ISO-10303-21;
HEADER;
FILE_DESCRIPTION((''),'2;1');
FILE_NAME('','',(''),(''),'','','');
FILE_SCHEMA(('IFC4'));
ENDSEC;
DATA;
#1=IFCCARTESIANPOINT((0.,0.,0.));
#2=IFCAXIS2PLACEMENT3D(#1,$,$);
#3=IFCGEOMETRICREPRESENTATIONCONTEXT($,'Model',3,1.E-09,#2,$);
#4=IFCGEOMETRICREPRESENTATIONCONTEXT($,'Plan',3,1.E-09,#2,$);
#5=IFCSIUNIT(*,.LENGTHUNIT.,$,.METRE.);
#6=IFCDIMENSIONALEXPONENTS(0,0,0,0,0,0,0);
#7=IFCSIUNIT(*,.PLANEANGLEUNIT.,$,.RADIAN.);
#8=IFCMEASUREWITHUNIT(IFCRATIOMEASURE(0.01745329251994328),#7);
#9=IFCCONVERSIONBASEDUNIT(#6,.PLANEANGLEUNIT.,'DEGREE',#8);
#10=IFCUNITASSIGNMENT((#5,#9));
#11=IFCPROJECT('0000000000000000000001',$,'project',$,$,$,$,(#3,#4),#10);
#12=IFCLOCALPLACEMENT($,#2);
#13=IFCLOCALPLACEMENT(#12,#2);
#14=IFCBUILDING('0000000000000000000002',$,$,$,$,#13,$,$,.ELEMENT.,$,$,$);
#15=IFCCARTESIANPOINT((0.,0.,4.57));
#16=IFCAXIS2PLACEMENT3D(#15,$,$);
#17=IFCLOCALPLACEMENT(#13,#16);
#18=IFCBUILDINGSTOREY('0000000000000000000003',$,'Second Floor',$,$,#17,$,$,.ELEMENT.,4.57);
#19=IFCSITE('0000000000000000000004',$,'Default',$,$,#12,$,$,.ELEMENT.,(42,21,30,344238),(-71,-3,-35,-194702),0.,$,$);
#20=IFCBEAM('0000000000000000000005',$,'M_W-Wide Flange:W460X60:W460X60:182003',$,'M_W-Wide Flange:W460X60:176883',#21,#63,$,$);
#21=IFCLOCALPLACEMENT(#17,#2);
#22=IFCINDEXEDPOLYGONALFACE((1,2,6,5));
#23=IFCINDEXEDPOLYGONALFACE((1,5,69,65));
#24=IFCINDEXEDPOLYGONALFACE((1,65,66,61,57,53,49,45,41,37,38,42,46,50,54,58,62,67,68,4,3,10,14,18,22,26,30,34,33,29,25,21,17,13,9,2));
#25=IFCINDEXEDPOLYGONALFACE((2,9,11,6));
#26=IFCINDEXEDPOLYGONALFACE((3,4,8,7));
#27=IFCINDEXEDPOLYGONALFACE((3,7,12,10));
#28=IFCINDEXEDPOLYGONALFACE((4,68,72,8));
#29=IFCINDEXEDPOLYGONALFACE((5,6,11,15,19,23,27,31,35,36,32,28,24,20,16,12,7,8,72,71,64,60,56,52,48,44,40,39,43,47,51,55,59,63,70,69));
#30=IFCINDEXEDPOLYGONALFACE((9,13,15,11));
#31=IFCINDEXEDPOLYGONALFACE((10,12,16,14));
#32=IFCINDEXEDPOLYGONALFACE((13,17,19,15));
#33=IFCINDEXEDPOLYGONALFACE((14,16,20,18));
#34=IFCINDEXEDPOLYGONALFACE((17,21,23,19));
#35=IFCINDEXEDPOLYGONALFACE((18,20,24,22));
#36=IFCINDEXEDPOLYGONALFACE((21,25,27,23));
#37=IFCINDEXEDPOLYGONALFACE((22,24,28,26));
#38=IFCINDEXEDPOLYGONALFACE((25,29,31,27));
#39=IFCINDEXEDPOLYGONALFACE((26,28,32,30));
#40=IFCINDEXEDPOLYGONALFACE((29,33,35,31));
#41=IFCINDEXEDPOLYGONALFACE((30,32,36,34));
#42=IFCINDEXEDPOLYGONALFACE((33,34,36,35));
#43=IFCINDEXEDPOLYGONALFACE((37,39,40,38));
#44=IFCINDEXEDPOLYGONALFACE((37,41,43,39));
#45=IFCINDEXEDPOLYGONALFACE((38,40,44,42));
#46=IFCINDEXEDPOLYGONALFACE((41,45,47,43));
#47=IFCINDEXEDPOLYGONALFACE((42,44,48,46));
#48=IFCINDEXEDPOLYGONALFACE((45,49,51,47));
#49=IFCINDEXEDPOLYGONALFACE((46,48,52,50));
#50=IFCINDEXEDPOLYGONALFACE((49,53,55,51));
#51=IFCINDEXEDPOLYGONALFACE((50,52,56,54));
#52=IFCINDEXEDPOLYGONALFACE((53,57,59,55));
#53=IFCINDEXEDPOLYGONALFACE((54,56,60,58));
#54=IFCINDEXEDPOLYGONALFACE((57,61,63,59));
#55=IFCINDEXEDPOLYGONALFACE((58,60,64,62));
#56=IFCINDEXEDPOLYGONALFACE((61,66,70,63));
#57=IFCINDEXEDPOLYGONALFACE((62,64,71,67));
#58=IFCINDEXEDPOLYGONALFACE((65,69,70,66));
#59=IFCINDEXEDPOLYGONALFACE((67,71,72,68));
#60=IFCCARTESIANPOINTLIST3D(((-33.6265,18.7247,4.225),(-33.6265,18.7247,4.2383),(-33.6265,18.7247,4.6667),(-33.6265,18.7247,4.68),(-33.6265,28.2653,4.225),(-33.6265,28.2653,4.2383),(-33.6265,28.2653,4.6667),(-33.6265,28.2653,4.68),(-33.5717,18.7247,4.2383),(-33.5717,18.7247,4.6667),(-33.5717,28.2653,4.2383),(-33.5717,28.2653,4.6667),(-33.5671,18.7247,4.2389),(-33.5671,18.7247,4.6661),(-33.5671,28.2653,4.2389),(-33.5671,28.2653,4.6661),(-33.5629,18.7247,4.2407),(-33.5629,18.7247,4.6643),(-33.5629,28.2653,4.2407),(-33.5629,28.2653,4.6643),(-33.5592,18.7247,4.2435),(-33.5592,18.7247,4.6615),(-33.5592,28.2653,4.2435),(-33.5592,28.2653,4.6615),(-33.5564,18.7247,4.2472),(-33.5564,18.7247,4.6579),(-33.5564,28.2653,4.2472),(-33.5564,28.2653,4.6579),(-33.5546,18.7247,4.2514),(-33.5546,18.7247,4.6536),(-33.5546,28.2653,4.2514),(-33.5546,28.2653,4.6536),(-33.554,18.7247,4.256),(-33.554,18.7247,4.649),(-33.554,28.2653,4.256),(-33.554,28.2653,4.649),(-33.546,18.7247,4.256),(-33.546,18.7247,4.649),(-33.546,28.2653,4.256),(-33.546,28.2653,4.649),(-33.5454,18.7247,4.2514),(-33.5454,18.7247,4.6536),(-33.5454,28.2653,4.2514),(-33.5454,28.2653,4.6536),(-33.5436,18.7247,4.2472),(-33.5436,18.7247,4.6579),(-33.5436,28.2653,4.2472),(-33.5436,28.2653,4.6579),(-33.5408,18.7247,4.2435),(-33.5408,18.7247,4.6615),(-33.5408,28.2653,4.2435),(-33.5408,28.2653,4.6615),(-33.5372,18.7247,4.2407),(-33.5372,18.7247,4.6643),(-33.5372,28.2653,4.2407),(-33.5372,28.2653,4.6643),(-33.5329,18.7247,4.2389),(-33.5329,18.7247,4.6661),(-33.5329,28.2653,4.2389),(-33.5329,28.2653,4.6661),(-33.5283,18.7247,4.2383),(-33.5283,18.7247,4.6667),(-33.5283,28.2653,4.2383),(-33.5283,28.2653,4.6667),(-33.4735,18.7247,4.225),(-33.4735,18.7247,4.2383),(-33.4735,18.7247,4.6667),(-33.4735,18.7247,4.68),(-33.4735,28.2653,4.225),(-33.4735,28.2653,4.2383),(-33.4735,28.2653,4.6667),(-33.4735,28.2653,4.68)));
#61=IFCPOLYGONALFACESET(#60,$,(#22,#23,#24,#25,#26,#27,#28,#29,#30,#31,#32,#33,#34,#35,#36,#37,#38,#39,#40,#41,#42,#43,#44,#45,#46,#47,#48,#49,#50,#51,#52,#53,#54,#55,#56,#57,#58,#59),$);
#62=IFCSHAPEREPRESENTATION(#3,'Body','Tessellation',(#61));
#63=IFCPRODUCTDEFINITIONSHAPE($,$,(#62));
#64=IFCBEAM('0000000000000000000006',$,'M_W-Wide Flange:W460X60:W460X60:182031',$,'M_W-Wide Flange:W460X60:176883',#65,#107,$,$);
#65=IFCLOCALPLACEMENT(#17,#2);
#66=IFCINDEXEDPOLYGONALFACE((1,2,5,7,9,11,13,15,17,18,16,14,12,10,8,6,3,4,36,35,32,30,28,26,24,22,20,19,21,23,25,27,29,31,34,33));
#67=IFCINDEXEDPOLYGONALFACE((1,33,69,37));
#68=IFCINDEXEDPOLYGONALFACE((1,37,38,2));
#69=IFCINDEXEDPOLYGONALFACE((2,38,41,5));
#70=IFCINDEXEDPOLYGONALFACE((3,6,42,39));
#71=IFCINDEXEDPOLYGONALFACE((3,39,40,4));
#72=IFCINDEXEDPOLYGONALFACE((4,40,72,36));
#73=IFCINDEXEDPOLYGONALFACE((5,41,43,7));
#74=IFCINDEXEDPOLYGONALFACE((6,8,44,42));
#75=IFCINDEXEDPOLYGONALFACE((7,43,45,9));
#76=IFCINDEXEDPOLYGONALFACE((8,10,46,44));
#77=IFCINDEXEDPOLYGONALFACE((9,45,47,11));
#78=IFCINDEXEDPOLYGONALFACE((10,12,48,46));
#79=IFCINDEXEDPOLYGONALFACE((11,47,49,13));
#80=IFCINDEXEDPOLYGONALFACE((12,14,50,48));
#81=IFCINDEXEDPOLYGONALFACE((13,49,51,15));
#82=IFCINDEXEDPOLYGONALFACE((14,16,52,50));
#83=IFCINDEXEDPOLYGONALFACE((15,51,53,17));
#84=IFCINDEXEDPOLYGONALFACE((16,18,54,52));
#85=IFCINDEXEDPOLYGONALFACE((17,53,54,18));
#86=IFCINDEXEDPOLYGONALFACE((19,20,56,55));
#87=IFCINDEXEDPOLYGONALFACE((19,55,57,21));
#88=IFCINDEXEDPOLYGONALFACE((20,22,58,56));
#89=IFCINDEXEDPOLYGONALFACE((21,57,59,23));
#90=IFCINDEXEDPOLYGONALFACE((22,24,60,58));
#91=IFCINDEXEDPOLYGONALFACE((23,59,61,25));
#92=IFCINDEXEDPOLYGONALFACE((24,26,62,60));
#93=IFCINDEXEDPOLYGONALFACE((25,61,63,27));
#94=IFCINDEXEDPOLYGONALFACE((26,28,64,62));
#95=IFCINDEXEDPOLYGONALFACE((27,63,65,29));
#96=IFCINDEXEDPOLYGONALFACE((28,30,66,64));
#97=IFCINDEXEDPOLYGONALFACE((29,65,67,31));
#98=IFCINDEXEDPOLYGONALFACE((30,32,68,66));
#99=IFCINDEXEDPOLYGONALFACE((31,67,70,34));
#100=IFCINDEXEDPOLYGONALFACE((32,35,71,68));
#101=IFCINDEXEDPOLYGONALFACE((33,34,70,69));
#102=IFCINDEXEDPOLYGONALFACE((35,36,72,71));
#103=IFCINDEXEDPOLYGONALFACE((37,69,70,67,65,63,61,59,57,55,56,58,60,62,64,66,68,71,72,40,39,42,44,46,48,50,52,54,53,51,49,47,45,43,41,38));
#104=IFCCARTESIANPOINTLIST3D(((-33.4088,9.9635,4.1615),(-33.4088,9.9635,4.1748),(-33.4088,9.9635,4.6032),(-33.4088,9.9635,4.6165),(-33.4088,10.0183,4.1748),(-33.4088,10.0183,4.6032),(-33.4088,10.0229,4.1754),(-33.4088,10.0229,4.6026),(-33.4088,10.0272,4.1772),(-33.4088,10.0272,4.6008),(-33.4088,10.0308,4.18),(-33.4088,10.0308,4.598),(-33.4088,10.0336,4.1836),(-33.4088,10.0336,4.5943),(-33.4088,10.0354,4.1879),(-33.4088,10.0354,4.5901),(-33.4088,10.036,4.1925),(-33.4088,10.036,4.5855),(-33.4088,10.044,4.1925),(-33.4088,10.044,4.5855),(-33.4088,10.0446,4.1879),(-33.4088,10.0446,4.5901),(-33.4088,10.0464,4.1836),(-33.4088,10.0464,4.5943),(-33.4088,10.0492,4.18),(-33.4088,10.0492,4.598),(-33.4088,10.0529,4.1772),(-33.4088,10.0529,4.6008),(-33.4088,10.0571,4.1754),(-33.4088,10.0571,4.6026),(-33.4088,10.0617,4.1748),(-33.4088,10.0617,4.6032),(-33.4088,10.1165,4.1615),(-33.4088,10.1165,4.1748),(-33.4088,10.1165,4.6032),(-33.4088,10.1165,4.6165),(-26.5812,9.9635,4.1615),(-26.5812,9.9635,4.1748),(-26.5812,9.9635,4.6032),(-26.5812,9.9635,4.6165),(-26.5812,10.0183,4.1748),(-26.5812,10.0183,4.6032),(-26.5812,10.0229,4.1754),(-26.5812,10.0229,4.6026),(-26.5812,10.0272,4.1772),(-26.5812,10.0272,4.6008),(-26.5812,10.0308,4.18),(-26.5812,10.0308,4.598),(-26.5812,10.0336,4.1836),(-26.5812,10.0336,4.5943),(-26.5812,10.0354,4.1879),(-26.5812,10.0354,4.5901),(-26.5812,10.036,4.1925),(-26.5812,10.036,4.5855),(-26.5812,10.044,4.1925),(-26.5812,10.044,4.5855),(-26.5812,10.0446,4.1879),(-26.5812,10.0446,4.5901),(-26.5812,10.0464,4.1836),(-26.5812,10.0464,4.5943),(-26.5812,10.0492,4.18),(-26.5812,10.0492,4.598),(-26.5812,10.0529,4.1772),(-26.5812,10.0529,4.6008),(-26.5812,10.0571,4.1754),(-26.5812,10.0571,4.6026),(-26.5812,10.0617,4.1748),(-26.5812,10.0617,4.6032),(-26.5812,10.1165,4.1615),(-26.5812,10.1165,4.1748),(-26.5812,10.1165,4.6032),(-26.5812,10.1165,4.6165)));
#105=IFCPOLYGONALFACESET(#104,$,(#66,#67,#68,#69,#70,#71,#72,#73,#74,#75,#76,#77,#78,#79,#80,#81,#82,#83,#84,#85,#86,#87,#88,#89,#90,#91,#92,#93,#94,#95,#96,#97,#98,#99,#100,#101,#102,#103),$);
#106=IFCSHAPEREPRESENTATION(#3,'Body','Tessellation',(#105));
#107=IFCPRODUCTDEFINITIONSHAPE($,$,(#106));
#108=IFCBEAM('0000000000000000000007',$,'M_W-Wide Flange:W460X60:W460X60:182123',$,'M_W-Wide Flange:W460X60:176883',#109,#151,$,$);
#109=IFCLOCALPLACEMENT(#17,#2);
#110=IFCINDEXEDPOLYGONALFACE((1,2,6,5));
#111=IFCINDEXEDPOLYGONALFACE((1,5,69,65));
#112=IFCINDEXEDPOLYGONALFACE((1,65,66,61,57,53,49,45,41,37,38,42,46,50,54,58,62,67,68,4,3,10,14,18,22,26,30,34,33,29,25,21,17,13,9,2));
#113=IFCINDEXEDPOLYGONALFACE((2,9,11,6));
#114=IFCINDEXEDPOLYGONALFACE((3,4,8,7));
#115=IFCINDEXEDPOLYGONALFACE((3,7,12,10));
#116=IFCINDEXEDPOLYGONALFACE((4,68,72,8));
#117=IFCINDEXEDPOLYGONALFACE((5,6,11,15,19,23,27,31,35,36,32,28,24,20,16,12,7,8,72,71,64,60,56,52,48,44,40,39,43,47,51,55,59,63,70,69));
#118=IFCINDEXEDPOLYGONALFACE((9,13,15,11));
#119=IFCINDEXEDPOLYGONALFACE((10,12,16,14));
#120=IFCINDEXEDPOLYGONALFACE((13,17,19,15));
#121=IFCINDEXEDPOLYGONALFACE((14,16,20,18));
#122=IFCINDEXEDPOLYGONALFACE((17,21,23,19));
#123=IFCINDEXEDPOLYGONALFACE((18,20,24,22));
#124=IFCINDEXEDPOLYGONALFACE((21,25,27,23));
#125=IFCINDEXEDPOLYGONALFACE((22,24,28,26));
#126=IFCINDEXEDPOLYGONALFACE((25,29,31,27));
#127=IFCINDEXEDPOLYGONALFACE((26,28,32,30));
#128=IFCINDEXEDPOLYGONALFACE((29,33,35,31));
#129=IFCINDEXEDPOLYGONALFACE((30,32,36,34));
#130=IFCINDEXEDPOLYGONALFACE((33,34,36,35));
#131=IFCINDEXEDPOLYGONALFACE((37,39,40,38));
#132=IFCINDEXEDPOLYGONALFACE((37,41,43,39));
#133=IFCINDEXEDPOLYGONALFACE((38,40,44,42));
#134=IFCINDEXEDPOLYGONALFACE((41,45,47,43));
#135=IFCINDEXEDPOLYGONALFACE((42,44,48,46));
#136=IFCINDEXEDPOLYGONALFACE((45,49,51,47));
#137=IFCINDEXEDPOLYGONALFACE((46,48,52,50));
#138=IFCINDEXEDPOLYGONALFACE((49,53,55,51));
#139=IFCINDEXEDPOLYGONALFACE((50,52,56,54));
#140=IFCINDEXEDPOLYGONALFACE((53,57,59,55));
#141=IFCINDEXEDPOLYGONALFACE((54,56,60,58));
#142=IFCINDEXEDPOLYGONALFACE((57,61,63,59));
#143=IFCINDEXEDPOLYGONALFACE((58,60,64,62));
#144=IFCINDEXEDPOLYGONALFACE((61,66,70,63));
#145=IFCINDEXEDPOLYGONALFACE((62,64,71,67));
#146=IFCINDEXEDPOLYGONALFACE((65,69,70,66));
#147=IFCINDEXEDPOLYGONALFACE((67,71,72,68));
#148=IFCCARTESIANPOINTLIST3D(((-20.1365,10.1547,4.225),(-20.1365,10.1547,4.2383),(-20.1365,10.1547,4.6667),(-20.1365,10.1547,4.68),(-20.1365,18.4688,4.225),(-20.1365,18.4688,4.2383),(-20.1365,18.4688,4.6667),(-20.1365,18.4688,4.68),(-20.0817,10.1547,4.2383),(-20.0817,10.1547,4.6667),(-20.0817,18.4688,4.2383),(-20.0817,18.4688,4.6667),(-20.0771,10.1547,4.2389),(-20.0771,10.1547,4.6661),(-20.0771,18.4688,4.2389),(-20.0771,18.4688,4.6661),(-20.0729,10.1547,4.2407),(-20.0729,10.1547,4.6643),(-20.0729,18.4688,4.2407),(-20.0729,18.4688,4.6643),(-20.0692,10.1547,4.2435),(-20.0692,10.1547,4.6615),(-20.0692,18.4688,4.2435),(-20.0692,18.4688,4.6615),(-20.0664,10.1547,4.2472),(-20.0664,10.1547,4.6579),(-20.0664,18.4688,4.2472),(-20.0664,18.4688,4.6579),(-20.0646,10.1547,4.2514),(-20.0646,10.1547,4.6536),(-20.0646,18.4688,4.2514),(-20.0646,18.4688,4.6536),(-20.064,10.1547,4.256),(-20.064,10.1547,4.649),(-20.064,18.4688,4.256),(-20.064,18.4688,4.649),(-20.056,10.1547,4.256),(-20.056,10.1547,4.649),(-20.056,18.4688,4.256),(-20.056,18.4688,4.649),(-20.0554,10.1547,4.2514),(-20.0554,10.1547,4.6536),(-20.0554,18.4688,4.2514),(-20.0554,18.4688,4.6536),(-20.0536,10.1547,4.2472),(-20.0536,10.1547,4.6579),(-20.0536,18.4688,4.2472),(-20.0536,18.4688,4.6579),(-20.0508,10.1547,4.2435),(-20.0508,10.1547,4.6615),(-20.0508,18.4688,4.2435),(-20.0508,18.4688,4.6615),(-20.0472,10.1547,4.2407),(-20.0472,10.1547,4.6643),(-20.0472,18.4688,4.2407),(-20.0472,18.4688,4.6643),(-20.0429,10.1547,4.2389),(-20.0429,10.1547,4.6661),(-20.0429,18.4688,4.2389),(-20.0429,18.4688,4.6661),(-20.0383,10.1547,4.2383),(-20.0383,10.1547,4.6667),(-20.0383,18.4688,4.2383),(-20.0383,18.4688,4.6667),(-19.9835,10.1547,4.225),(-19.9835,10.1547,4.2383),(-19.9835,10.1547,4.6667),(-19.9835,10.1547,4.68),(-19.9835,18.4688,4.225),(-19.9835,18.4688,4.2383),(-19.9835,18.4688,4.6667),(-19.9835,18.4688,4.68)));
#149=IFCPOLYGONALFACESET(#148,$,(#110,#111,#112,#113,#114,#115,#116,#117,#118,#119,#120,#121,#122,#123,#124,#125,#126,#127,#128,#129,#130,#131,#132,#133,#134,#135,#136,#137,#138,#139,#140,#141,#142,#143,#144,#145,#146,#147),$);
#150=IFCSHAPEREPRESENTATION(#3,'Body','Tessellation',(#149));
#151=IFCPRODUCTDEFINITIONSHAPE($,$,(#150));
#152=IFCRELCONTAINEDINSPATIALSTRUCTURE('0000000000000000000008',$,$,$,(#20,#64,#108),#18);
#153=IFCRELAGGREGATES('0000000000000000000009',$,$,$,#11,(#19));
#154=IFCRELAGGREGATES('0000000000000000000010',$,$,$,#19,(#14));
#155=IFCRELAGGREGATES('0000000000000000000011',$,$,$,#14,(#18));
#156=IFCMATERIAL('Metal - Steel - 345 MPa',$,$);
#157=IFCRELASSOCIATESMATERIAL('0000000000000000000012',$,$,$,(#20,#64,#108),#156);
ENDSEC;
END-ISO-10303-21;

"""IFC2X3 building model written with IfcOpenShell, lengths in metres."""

from ifc_helpers import new_model, entity, si_unit, converted_unit, frame, frame_2d, origin, place, context, project, spatial, polyline, circle_curve, parameter, trimmed, segment, composite_curve, outline, extrude, material, element, save


model = new_model("IFC2X3")

# Units and contexts
model_context = context("Model", 3, precision=1e-09, world=origin())
plan_context = context("Plan", 3, precision=1e-09, world=origin())
ifc_project = project(units=[si_unit("LENGTHUNIT", "METRE"), converted_unit("PLANEANGLEUNIT", "DEGREE", entity("IfcRatioMeasure", 0.01745329251994328), si_unit("PLANEANGLEUNIT", "RADIAN"), dimensions=[0, 0, 0, 0, 0, 0, 0])], contexts=[model_context, plan_context])

# Site, building, storey
site_placement = place(None, origin())
site = spatial("IfcSite", under=ifc_project, at=site_placement, Name="Default", CompositionType="ELEMENT", RefLatitude=(42, 21, 30, 344238), RefLongitude=(-71, -3, -35, -194702), RefElevation=0.0)
building_placement = place(site_placement, origin())
building = spatial("IfcBuilding", under=site, at=building_placement, CompositionType="ELEMENT")
storey_placement = place(building_placement, frame((0.0, 0.0, 4.57)))
storey = spatial("IfcBuildingStorey", under=building, at=storey_placement, Name="Second Floor", CompositionType="ELEMENT", Elevation=4.57)

# Shared definitions
ifc_material = material(Name="Metal - Steel - 345 MPa")

# Beams
beam_1_placement = place(storey_placement, frame((-33.55, 28.3781, 4.68), z_axis=(0.0, 0.0, 1.0), x_axis=(-1.0, 0.0, 0.0)))
element("IfcBeam", 1, at=beam_1_placement, inside=storey, material=ifc_material, Name="M_W-Wide Flange:W460X60:W460X60:182003", ObjectType="M_W-Wide Flange:W460X60:176883", context=model_context, shape_type="SweptSolid", body=[
    extrude(outline(composite_curve([segment(polyline([(0.2142, -0.0765), (0.2275, -0.0765)]), True, "CONTINUOUS"), segment(polyline([(0.2275, -0.0765), (0.2275, 0.0765)]), True, "CONTINUOUS"), segment(polyline([(0.2275, 0.0765), (0.2142, 0.0765)]), True, "CONTINUOUS"), segment(polyline([(0.2142, 0.0765), (0.2142, 0.0217)]), True, "CONTINUOUS"), segment(trimmed(circle_curve(frame_2d((0.1965, 0.0217), x_axis=(1.0, 0.0)), 0.0177), [parameter(270.0)], [parameter(360.0)], True, "PARAMETER"), False, "CONTINUOUS"), segment(polyline([(0.1965, 0.004), (-0.1965, 0.004)]), True, "CONTINUOUS"), segment(trimmed(circle_curve(frame_2d((-0.1965, 0.0217), x_axis=(0.0, -1.0)), 0.0177), [parameter(270.0)], [parameter(360.0)], True, "PARAMETER"), False, "CONTINUOUS"), segment(polyline([(-0.2142, 0.0217), (-0.2142, 0.0765)]), True, "CONTINUOUS"), segment(polyline([(-0.2142, 0.0765), (-0.2275, 0.0765)]), True, "CONTINUOUS"), segment(polyline([(-0.2275, 0.0765), (-0.2275, -0.0765)]), True, "CONTINUOUS"), segment(polyline([(-0.2275, -0.0765), (-0.2142, -0.0765)]), True, "CONTINUOUS"), segment(polyline([(-0.2142, -0.0765), (-0.2142, -0.0217)]), True, "CONTINUOUS"), segment(trimmed(circle_curve(frame_2d((-0.1965, -0.0217), x_axis=(-1.0, 0.0)), 0.0177), [parameter(270.0)], [parameter(360.0)], True, "PARAMETER"), False, "CONTINUOUS"), segment(polyline([(-0.1965, -0.004), (0.1965, -0.004)]), True, "CONTINUOUS"), segment(trimmed(circle_curve(frame_2d((0.1965, -0.0217), x_axis=(0.0, 1.0)), 0.0177), [parameter(270.0)], [parameter(0.0)], True, "PARAMETER"), False, "CONTINUOUS"), segment(polyline([(0.2142, -0.0217), (0.2142, -0.0765)]), True, "CONTINUOUS")], self_intersect=False)), frame((0.0, 9.6534, -0.2275), z_axis=(0.0, -1.0, 0.0), x_axis=(0.0, 0.0, -1.0)), (0.0, 0.0, 1.0), 9.5406),
])
beam_2_placement = place(storey_placement, frame((-33.5473, 10.04, 4.6165), z_axis=(0.0, 0.0, 1.0), x_axis=(0.0, -1.0, 0.0)))
element("IfcBeam", 2, at=beam_2_placement, inside=storey, material=ifc_material, Name="M_W-Wide Flange:W460X60:W460X60:182031", ObjectType="M_W-Wide Flange:W460X60:176883", context=model_context, shape_type="SweptSolid", body=[
    extrude(outline(composite_curve([segment(polyline([(-0.0765, -0.2142), (-0.0765, -0.2275)]), True, "CONTINUOUS"), segment(polyline([(-0.0765, -0.2275), (0.0765, -0.2275)]), True, "CONTINUOUS"), segment(polyline([(0.0765, -0.2275), (0.0765, -0.2142)]), True, "CONTINUOUS"), segment(polyline([(0.0765, -0.2142), (0.0217, -0.2142)]), True, "CONTINUOUS"), segment(trimmed(circle_curve(frame_2d((0.0217, -0.1965), x_axis=(0.0, -1.0)), 0.0177), [parameter(270.0)], [parameter(360.0)], True, "PARAMETER"), False, "CONTINUOUS"), segment(polyline([(0.004, -0.1965), (0.004, 0.1965)]), True, "CONTINUOUS"), segment(trimmed(circle_curve(frame_2d((0.0217, 0.1965), x_axis=(-1.0, 0.0)), 0.0177), [parameter(270.0)], [parameter(360.0)], True, "PARAMETER"), False, "CONTINUOUS"), segment(polyline([(0.0217, 0.2142), (0.0765, 0.2142)]), True, "CONTINUOUS"), segment(polyline([(0.0765, 0.2142), (0.0765, 0.2275)]), True, "CONTINUOUS"), segment(polyline([(0.0765, 0.2275), (-0.0765, 0.2275)]), True, "CONTINUOUS"), segment(polyline([(-0.0765, 0.2275), (-0.0765, 0.2142)]), True, "CONTINUOUS"), segment(polyline([(-0.0765, 0.2142), (-0.0217, 0.2142)]), True, "CONTINUOUS"), segment(trimmed(circle_curve(frame_2d((-0.0217, 0.1965), x_axis=(0.0, 1.0)), 0.0177), [parameter(270.0)], [parameter(360.0)], True, "PARAMETER"), False, "CONTINUOUS"), segment(polyline([(-0.004, 0.1965), (-0.004, -0.1965)]), True, "CONTINUOUS"), segment(trimmed(circle_curve(frame_2d((-0.0217, -0.1965), x_axis=(1.0, 0.0)), 0.0177), [parameter(270.0)], [parameter(0.0)], True, "PARAMETER"), False, "CONTINUOUS"), segment(polyline([(-0.0217, -0.2142), (-0.0765, -0.2142)]), True, "CONTINUOUS")], self_intersect=False)), frame((0.0, 0.1385, -0.2275), z_axis=(0.0, -1.0, 0.0), x_axis=(1.0, 0.0, 0.0)), (0.0, 0.0, -1.0), 6.8276),
])
beam_3_placement = place(storey_placement, frame((-20.06, 10.0422, 4.68)))
element("IfcBeam", 3, at=beam_3_placement, inside=storey, material=ifc_material, Name="M_W-Wide Flange:W460X60:W460X60:182123", ObjectType="M_W-Wide Flange:W460X60:176883", context=model_context, shape_type="SweptSolid", body=[
    extrude(outline(composite_curve([segment(polyline([(-0.0765, -0.2142), (-0.0765, -0.2275)]), True, "CONTINUOUS"), segment(polyline([(-0.0765, -0.2275), (0.0765, -0.2275)]), True, "CONTINUOUS"), segment(polyline([(0.0765, -0.2275), (0.0765, -0.2142)]), True, "CONTINUOUS"), segment(polyline([(0.0765, -0.2142), (0.0217, -0.2142)]), True, "CONTINUOUS"), segment(trimmed(circle_curve(frame_2d((0.0217, -0.1965), x_axis=(0.0, -1.0)), 0.0177), [parameter(270.0)], [parameter(360.0)], True, "PARAMETER"), False, "CONTINUOUS"), segment(polyline([(0.004, -0.1965), (0.004, 0.1965)]), True, "CONTINUOUS"), segment(trimmed(circle_curve(frame_2d((0.0217, 0.1965), x_axis=(-1.0, 0.0)), 0.0177), [parameter(270.0)], [parameter(360.0)], True, "PARAMETER"), False, "CONTINUOUS"), segment(polyline([(0.0217, 0.2142), (0.0765, 0.2142)]), True, "CONTINUOUS"), segment(polyline([(0.0765, 0.2142), (0.0765, 0.2275)]), True, "CONTINUOUS"), segment(polyline([(0.0765, 0.2275), (-0.0765, 0.2275)]), True, "CONTINUOUS"), segment(polyline([(-0.0765, 0.2275), (-0.0765, 0.2142)]), True, "CONTINUOUS"), segment(polyline([(-0.0765, 0.2142), (-0.0217, 0.2142)]), True, "CONTINUOUS"), segment(trimmed(circle_curve(frame_2d((-0.0217, 0.1965), x_axis=(0.0, 1.0)), 0.0177), [parameter(270.0)], [parameter(360.0)], True, "PARAMETER"), False, "CONTINUOUS"), segment(polyline([(-0.004, 0.1965), (-0.004, -0.1965)]), True, "CONTINUOUS"), segment(trimmed(circle_curve(frame_2d((-0.0217, -0.1965), x_axis=(1.0, 0.0)), 0.0177), [parameter(270.0)], [parameter(0.0)], True, "PARAMETER"), False, "CONTINUOUS"), segment(polyline([(-0.0217, -0.2142), (-0.0765, -0.2142)]), True, "CONTINUOUS")], self_intersect=False)), frame((0.0, 0.1125, -0.2275), z_axis=(0.0, -1.0, 0.0), x_axis=(1.0, 0.0, 0.0)), (0.0, 0.0, -1.0), 8.3141),
])

save(model, "model.ifc")
